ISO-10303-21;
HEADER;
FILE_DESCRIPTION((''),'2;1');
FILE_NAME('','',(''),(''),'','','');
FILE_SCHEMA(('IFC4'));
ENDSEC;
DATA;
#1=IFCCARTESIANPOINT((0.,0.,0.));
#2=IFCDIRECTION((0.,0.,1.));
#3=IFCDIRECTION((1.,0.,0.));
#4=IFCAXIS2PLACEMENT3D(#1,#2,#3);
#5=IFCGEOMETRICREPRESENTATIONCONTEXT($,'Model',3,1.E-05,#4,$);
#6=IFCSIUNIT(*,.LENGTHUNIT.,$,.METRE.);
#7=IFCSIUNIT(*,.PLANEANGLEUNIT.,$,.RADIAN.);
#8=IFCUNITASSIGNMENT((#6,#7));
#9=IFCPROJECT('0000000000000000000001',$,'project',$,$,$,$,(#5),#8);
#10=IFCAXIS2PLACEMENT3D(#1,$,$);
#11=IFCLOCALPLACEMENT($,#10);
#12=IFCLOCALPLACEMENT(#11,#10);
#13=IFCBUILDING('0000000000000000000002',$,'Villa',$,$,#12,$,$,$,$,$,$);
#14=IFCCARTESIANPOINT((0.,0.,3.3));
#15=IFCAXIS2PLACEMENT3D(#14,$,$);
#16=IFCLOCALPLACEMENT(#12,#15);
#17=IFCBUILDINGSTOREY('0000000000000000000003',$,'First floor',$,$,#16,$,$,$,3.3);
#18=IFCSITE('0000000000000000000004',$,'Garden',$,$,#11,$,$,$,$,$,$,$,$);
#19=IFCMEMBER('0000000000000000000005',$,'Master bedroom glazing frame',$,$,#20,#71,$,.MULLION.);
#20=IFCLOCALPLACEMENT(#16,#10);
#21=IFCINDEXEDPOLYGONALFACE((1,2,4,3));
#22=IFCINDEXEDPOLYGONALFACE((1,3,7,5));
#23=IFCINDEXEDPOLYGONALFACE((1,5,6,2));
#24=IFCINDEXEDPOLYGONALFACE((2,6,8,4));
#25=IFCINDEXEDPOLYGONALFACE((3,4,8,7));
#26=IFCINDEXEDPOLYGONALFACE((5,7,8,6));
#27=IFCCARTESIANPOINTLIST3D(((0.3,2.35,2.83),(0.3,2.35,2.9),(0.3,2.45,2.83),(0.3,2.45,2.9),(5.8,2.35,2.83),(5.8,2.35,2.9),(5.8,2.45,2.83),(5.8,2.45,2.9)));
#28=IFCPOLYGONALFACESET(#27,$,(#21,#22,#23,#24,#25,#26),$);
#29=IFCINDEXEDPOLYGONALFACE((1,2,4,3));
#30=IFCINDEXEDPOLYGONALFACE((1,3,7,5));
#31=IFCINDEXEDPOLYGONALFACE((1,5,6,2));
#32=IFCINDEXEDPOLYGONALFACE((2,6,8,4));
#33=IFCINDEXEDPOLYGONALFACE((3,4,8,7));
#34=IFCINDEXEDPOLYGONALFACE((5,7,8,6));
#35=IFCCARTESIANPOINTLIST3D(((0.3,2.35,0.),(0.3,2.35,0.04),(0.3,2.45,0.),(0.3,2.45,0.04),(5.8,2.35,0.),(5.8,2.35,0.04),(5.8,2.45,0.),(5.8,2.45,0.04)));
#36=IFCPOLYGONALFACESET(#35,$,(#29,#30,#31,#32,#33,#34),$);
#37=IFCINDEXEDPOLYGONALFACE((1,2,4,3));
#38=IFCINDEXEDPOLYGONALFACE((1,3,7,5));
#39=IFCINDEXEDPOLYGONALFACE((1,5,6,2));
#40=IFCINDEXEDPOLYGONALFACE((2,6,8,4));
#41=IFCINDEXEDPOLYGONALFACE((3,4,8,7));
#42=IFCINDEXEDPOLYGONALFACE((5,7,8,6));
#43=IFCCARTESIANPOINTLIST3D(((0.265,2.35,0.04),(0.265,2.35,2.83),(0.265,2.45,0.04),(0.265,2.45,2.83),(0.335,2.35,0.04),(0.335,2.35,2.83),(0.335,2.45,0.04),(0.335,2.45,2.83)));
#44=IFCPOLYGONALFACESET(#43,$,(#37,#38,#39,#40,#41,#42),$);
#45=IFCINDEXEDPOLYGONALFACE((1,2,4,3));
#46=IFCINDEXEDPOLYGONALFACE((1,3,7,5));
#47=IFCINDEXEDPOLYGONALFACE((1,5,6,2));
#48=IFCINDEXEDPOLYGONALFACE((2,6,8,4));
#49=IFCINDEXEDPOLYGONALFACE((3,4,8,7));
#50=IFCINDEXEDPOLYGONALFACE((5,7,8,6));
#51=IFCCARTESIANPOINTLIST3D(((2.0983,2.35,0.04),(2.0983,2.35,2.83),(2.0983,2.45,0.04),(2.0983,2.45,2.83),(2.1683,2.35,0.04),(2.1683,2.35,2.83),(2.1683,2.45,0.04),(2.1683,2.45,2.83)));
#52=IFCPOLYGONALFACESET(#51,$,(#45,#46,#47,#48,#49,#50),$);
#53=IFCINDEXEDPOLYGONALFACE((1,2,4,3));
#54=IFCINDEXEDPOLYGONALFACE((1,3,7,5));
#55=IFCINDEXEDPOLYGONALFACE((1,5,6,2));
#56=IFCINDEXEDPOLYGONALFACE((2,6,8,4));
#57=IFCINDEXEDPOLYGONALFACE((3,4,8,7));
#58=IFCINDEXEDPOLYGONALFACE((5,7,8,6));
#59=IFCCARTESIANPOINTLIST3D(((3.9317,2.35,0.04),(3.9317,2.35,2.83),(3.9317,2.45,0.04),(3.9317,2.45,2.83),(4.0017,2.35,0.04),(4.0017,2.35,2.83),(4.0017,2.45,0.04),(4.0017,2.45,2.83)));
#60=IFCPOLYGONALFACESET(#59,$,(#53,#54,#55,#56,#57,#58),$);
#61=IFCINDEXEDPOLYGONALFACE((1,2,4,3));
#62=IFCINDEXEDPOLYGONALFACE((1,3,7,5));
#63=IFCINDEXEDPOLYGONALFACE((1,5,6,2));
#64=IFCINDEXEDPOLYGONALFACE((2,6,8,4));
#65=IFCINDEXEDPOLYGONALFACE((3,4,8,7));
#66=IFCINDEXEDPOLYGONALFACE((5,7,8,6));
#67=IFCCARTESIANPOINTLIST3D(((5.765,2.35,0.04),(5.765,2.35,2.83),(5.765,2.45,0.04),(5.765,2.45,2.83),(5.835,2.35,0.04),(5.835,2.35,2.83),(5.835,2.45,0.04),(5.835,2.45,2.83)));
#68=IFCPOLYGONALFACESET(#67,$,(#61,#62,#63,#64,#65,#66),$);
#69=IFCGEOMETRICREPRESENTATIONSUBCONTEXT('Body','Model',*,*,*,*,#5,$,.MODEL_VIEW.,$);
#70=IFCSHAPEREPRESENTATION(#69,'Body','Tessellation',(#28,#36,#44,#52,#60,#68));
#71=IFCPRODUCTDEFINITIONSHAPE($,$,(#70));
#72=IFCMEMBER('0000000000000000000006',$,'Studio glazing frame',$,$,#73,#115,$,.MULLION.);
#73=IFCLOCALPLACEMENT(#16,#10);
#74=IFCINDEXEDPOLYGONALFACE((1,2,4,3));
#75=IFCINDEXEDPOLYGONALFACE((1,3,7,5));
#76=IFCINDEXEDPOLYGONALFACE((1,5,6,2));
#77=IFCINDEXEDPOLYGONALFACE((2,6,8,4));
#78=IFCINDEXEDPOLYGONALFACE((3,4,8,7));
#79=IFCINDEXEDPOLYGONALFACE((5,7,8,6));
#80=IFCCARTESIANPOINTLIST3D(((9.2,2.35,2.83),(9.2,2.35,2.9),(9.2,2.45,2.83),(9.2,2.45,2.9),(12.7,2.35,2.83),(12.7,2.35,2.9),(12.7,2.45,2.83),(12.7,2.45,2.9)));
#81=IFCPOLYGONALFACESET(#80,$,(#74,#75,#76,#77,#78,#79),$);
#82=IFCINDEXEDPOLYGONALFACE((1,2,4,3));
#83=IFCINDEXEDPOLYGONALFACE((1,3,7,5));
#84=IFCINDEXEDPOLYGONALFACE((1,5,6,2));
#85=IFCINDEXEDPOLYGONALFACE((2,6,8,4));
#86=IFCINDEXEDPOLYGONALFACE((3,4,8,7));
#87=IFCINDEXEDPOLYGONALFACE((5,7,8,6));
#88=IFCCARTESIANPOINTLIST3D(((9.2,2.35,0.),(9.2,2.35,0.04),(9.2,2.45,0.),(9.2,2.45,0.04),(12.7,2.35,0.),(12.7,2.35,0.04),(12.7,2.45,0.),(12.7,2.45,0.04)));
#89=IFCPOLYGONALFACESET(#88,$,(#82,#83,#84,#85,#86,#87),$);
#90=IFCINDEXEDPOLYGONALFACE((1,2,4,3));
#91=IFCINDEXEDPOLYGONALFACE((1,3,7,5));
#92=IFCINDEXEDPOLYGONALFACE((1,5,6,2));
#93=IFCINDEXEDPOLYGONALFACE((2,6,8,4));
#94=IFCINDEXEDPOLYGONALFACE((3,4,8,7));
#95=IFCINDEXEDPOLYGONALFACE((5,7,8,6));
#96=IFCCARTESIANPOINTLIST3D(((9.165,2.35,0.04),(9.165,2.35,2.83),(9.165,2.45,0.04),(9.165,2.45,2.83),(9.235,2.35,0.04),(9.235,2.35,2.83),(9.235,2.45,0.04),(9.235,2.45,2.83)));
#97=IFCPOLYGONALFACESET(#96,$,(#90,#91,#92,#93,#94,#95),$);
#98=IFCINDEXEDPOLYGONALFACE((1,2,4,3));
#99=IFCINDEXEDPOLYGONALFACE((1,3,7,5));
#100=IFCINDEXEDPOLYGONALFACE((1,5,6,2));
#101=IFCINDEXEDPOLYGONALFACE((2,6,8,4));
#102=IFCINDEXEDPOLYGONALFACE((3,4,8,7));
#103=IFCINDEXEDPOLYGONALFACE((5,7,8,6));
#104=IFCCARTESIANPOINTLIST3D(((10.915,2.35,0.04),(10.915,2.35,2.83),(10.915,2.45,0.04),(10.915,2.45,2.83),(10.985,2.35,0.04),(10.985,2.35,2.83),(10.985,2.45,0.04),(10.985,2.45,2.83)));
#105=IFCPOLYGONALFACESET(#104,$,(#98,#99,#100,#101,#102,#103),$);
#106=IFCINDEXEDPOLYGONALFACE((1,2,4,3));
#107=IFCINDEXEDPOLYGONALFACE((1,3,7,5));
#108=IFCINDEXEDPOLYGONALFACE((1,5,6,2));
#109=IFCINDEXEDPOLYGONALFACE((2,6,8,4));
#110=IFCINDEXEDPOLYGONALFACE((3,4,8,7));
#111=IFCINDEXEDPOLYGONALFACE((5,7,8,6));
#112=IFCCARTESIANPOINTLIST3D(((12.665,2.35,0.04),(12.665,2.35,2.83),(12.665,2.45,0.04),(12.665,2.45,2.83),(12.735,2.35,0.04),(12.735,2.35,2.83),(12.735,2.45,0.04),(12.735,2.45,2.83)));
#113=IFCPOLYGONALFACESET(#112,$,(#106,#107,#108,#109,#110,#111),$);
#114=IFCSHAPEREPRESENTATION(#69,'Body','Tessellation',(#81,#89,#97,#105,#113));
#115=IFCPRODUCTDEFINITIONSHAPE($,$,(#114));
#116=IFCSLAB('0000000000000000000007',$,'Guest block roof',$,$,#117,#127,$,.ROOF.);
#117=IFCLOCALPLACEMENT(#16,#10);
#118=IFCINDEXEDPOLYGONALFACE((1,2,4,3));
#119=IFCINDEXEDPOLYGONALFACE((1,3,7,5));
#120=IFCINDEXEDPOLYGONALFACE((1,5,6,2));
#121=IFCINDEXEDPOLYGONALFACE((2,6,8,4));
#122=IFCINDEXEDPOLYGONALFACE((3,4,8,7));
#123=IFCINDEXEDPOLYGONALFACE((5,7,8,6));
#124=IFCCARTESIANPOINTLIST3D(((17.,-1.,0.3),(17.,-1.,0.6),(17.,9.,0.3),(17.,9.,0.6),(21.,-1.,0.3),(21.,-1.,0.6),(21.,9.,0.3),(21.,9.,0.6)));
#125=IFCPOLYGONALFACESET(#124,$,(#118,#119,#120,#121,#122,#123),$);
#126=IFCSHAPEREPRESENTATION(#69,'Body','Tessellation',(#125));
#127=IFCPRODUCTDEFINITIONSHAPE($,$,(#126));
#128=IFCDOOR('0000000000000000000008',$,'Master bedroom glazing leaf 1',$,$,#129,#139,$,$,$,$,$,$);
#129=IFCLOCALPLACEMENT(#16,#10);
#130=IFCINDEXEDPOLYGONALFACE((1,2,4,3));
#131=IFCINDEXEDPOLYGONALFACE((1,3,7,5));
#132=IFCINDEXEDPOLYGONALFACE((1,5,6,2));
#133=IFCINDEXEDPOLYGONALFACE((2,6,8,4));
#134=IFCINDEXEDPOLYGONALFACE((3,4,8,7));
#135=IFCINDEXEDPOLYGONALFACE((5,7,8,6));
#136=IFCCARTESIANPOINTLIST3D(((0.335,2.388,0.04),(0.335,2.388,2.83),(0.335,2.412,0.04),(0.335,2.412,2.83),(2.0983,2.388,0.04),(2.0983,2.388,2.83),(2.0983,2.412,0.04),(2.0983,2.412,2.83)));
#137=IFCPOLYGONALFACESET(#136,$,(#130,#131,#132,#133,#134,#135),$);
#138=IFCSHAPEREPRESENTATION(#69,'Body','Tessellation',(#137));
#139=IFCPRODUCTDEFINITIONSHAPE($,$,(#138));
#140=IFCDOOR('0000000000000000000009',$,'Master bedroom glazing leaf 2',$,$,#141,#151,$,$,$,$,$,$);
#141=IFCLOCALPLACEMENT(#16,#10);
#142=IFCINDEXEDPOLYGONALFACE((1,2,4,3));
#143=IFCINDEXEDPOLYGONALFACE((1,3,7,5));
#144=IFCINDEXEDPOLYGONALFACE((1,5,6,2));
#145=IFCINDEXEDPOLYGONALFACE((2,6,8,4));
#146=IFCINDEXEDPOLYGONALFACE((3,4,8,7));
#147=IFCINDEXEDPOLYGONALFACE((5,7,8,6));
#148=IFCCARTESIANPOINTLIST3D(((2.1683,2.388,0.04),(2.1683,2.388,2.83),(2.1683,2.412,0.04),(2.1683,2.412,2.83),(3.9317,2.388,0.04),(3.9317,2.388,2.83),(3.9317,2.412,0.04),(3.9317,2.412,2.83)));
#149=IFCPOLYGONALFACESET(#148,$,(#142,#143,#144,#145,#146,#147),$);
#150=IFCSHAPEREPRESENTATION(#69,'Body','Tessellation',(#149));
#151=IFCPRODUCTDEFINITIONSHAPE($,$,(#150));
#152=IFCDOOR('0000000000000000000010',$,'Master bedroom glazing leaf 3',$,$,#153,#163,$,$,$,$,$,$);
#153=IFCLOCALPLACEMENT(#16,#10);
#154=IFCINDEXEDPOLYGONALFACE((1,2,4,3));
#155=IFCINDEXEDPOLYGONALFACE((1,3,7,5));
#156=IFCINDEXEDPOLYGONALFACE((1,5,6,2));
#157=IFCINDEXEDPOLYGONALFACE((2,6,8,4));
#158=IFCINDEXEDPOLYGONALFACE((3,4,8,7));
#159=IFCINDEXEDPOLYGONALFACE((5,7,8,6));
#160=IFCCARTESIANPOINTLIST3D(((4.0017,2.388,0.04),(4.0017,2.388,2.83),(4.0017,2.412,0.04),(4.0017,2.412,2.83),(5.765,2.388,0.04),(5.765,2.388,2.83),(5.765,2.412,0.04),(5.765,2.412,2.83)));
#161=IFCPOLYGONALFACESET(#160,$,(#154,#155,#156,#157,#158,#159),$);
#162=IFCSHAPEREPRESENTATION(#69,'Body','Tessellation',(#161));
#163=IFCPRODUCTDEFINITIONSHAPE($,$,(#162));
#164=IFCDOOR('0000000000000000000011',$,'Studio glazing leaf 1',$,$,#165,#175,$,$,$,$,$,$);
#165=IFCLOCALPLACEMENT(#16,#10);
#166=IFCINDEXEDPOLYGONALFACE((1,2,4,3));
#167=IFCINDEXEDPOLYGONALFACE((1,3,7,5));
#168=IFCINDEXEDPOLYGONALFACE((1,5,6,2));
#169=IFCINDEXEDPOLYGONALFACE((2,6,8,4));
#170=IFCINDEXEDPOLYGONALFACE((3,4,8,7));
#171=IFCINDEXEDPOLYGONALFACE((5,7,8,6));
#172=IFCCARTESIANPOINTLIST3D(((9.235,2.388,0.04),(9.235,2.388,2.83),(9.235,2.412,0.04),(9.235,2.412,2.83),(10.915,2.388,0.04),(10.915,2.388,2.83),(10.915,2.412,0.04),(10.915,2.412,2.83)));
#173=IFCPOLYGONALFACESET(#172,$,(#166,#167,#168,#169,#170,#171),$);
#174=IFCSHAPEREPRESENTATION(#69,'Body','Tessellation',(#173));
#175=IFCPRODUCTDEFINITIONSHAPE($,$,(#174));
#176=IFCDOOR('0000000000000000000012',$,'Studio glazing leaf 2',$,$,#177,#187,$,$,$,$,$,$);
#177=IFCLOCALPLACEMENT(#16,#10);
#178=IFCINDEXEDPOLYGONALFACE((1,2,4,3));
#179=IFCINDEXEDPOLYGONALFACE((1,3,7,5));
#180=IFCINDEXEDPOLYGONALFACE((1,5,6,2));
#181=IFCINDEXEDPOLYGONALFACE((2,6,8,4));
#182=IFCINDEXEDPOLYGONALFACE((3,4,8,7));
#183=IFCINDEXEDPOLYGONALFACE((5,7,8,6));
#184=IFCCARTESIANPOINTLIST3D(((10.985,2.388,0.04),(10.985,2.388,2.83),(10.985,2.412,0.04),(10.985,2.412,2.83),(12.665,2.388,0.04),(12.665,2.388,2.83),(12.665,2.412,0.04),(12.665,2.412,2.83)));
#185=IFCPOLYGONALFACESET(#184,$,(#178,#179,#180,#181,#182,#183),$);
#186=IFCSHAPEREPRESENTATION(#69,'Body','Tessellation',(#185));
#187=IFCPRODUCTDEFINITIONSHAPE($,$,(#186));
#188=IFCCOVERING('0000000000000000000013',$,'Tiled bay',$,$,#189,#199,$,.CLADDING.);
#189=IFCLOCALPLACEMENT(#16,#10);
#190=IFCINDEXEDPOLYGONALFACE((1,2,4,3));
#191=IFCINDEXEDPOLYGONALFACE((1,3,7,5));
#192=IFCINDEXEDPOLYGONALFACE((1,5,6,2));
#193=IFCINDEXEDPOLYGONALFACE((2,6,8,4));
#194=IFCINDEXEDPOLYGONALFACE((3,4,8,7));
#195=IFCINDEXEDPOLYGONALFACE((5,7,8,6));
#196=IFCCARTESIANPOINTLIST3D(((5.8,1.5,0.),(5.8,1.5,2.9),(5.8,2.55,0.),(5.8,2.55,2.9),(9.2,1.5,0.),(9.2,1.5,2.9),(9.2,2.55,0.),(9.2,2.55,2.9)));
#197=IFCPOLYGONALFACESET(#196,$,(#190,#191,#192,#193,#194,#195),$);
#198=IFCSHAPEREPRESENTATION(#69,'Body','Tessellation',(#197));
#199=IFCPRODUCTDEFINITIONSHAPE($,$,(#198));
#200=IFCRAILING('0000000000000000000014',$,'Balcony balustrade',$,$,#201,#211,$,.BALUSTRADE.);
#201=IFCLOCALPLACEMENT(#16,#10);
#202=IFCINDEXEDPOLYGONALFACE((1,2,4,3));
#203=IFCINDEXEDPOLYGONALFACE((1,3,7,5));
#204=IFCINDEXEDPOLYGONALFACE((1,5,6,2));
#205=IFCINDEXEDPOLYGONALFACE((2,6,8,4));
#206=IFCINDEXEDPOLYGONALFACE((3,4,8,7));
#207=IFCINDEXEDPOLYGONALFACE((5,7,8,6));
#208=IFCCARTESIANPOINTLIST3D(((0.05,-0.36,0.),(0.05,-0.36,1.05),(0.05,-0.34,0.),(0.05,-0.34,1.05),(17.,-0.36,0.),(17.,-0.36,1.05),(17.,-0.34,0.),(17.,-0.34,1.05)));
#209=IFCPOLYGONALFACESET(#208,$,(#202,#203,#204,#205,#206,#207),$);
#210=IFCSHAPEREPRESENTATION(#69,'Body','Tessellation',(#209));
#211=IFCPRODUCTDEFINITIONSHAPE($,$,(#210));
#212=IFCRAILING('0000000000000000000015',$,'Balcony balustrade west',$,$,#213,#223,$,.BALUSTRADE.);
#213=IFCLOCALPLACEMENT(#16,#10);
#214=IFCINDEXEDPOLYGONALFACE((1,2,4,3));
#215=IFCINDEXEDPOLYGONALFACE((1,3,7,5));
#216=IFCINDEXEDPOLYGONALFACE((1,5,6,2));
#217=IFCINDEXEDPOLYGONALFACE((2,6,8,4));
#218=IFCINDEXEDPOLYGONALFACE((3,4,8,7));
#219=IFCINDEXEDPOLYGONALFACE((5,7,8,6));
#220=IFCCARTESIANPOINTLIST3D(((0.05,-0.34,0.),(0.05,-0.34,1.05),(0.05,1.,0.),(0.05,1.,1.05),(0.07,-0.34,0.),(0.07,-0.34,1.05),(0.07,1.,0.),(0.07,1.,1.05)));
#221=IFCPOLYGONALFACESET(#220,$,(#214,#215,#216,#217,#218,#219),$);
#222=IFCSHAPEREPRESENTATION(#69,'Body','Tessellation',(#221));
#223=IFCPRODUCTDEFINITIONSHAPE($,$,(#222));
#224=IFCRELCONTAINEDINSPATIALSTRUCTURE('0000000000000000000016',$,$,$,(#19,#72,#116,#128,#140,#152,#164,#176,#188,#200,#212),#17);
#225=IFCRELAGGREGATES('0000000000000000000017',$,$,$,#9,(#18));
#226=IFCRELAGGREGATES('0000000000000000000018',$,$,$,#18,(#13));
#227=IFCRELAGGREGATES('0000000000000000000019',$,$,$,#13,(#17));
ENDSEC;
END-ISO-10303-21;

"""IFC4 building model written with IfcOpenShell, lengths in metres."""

from ifc_helpers import new_model, si_unit, frame, frame_2d, origin, origin_with_axes, place, context, subcontext, project, spatial, polyline, rectangle, outline, extrude, element, save


model = new_model("IFC4")

# Units and contexts
model_context = context("Model", 3, precision=1e-05, world=origin_with_axes())
body_context = subcontext(model_context, "Body", "Model", "MODEL_VIEW")
ifc_project = project(units=[si_unit("LENGTHUNIT", "METRE"), si_unit("PLANEANGLEUNIT", "RADIAN")], contexts=[model_context])

# Site, building, storey
site_placement = place(None, origin())
site = spatial("IfcSite", under=ifc_project, at=site_placement, Name="Garden")
building_placement = place(site_placement, origin())
building = spatial("IfcBuilding", under=site, at=building_placement, Name="Villa")
storey_placement = place(building_placement, frame((0.0, 0.0, 3.3)))
storey = spatial("IfcBuildingStorey", under=building, at=storey_placement, Name="First floor", Elevation=3.3)

# Members
member_1_placement = place(storey_placement, origin())
element("IfcMember", 1, at=member_1_placement, inside=storey, Name="Master bedroom glazing frame", PredefinedType="MULLION", context=body_context, shape_type="SweptSolid", body=[
    extrude(rectangle(XDim=5.5, YDim=0.1, at=frame_2d((2.75, 0.05))), frame((0.3, 2.35, 2.83)), (0.0, 0.0, 1.0), 0.07),
    extrude(rectangle(XDim=5.5, YDim=0.1, at=frame_2d((2.75, 0.05))), frame((0.3, 2.35, 0.0)), (0.0, 0.0, 1.0), 0.04),
    extrude(rectangle(XDim=0.07, YDim=0.1, at=frame_2d((0.035, 0.05))), frame((0.265, 2.35, 0.04)), (0.0, 0.0, 1.0), 2.79),
    extrude(rectangle(XDim=0.07, YDim=0.1, at=frame_2d((0.035, 0.05))), frame((2.0983, 2.35, 0.04)), (0.0, 0.0, 1.0), 2.79),
    extrude(rectangle(XDim=0.07, YDim=0.1, at=frame_2d((0.035, 0.05))), frame((3.9317, 2.35, 0.04)), (0.0, 0.0, 1.0), 2.79),
    extrude(rectangle(XDim=0.07, YDim=0.1, at=frame_2d((0.035, 0.05))), frame((5.765, 2.35, 0.04)), (0.0, 0.0, 1.0), 2.79),
])
member_2_placement = place(storey_placement, origin())
element("IfcMember", 2, at=member_2_placement, inside=storey, Name="Studio glazing frame", PredefinedType="MULLION", context=body_context, shape_type="SweptSolid", body=[
    extrude(rectangle(XDim=3.5, YDim=0.1, at=frame_2d((1.75, 0.05))), frame((9.2, 2.35, 2.83)), (0.0, 0.0, 1.0), 0.07),
    extrude(rectangle(XDim=3.5, YDim=0.1, at=frame_2d((1.75, 0.05))), frame((9.2, 2.35, 0.0)), (0.0, 0.0, 1.0), 0.04),
    extrude(rectangle(XDim=0.07, YDim=0.1, at=frame_2d((0.035, 0.05))), frame((9.165, 2.35, 0.04)), (0.0, 0.0, 1.0), 2.79),
    extrude(rectangle(XDim=0.07, YDim=0.1, at=frame_2d((0.035, 0.05))), frame((10.915, 2.35, 0.04)), (0.0, 0.0, 1.0), 2.79),
    extrude(rectangle(XDim=0.07, YDim=0.1, at=frame_2d((0.035, 0.05))), frame((12.665, 2.35, 0.04)), (0.0, 0.0, 1.0), 2.79),
])

# Slab
slab_placement = place(storey_placement, frame((0.0, 0.0, 0.3)))
element("IfcSlab", 3, at=slab_placement, inside=storey, Name="Guest block roof", PredefinedType="ROOF", context=body_context, shape_type="SweptSolid", body=[
    extrude(outline(polyline([(17.0, -1.0), (21.0, -1.0), (21.0, 9.0), (17.0, 9.0), (17.0, -1.0)])), origin(), (0.0, 0.0, 1.0), 0.3),
])

# Doors
door_1_placement = place(storey_placement, origin())
element("IfcDoor", 4, at=door_1_placement, inside=storey, Name="Master bedroom glazing leaf 1", context=body_context, shape_type="SweptSolid", body=[
    extrude(rectangle(XDim=1.7633, YDim=0.024, at=frame_2d((0.8817, 0.012))), frame((0.335, 2.388, 0.04)), (0.0, 0.0, 1.0), 2.79),
])
door_2_placement = place(storey_placement, origin())
element("IfcDoor", 5, at=door_2_placement, inside=storey, Name="Master bedroom glazing leaf 2", context=body_context, shape_type="SweptSolid", body=[
    extrude(rectangle(XDim=1.7633, YDim=0.024, at=frame_2d((0.8817, 0.012))), frame((2.1683, 2.388, 0.04)), (0.0, 0.0, 1.0), 2.79),
])
door_3_placement = place(storey_placement, origin())
element("IfcDoor", 6, at=door_3_placement, inside=storey, Name="Master bedroom glazing leaf 3", context=body_context, shape_type="SweptSolid", body=[
    extrude(rectangle(XDim=1.7633, YDim=0.024, at=frame_2d((0.8817, 0.012))), frame((4.0017, 2.388, 0.04)), (0.0, 0.0, 1.0), 2.79),
])
door_4_placement = place(storey_placement, origin())
element("IfcDoor", 7, at=door_4_placement, inside=storey, Name="Studio glazing leaf 1", context=body_context, shape_type="SweptSolid", body=[
    extrude(rectangle(XDim=1.68, YDim=0.024, at=frame_2d((0.84, 0.012))), frame((9.235, 2.388, 0.04)), (0.0, 0.0, 1.0), 2.79),
])
door_5_placement = place(storey_placement, origin())
element("IfcDoor", 8, at=door_5_placement, inside=storey, Name="Studio glazing leaf 2", context=body_context, shape_type="SweptSolid", body=[
    extrude(rectangle(XDim=1.68, YDim=0.024, at=frame_2d((0.84, 0.012))), frame((10.985, 2.388, 0.04)), (0.0, 0.0, 1.0), 2.79),
])

# Covering
covering_1_placement = place(storey_placement, origin())
element("IfcCovering", 9, at=covering_1_placement, inside=storey, Name="Tiled bay", PredefinedType="CLADDING", context=body_context, shape_type="SweptSolid", body=[
    extrude(rectangle(XDim=3.4, YDim=1.05, at=frame_2d((1.7, 0.525))), frame((5.8, 1.5, 0.0)), (0.0, 0.0, 1.0), 2.9),
])

# Railings
railing_1_placement = place(storey_placement, origin())
element("IfcRailing", 10, at=railing_1_placement, inside=storey, Name="Balcony balustrade", PredefinedType="BALUSTRADE", context=body_context, shape_type="SweptSolid", body=[
    extrude(rectangle(XDim=16.95, YDim=0.02, at=frame_2d((8.475, 0.01))), frame((0.05, -0.36, 0.0)), (0.0, 0.0, 1.0), 1.05),
])
railing_2_placement = place(storey_placement, origin())
element("IfcRailing", 11, at=railing_2_placement, inside=storey, Name="Balcony balustrade west", PredefinedType="BALUSTRADE", context=body_context, shape_type="SweptSolid", body=[
    extrude(rectangle(XDim=0.02, YDim=1.34, at=frame_2d((0.01, 0.67))), frame((0.05, -0.34, 0.0)), (0.0, 0.0, 1.0), 1.05),
])

save(model, "model.ifc")
